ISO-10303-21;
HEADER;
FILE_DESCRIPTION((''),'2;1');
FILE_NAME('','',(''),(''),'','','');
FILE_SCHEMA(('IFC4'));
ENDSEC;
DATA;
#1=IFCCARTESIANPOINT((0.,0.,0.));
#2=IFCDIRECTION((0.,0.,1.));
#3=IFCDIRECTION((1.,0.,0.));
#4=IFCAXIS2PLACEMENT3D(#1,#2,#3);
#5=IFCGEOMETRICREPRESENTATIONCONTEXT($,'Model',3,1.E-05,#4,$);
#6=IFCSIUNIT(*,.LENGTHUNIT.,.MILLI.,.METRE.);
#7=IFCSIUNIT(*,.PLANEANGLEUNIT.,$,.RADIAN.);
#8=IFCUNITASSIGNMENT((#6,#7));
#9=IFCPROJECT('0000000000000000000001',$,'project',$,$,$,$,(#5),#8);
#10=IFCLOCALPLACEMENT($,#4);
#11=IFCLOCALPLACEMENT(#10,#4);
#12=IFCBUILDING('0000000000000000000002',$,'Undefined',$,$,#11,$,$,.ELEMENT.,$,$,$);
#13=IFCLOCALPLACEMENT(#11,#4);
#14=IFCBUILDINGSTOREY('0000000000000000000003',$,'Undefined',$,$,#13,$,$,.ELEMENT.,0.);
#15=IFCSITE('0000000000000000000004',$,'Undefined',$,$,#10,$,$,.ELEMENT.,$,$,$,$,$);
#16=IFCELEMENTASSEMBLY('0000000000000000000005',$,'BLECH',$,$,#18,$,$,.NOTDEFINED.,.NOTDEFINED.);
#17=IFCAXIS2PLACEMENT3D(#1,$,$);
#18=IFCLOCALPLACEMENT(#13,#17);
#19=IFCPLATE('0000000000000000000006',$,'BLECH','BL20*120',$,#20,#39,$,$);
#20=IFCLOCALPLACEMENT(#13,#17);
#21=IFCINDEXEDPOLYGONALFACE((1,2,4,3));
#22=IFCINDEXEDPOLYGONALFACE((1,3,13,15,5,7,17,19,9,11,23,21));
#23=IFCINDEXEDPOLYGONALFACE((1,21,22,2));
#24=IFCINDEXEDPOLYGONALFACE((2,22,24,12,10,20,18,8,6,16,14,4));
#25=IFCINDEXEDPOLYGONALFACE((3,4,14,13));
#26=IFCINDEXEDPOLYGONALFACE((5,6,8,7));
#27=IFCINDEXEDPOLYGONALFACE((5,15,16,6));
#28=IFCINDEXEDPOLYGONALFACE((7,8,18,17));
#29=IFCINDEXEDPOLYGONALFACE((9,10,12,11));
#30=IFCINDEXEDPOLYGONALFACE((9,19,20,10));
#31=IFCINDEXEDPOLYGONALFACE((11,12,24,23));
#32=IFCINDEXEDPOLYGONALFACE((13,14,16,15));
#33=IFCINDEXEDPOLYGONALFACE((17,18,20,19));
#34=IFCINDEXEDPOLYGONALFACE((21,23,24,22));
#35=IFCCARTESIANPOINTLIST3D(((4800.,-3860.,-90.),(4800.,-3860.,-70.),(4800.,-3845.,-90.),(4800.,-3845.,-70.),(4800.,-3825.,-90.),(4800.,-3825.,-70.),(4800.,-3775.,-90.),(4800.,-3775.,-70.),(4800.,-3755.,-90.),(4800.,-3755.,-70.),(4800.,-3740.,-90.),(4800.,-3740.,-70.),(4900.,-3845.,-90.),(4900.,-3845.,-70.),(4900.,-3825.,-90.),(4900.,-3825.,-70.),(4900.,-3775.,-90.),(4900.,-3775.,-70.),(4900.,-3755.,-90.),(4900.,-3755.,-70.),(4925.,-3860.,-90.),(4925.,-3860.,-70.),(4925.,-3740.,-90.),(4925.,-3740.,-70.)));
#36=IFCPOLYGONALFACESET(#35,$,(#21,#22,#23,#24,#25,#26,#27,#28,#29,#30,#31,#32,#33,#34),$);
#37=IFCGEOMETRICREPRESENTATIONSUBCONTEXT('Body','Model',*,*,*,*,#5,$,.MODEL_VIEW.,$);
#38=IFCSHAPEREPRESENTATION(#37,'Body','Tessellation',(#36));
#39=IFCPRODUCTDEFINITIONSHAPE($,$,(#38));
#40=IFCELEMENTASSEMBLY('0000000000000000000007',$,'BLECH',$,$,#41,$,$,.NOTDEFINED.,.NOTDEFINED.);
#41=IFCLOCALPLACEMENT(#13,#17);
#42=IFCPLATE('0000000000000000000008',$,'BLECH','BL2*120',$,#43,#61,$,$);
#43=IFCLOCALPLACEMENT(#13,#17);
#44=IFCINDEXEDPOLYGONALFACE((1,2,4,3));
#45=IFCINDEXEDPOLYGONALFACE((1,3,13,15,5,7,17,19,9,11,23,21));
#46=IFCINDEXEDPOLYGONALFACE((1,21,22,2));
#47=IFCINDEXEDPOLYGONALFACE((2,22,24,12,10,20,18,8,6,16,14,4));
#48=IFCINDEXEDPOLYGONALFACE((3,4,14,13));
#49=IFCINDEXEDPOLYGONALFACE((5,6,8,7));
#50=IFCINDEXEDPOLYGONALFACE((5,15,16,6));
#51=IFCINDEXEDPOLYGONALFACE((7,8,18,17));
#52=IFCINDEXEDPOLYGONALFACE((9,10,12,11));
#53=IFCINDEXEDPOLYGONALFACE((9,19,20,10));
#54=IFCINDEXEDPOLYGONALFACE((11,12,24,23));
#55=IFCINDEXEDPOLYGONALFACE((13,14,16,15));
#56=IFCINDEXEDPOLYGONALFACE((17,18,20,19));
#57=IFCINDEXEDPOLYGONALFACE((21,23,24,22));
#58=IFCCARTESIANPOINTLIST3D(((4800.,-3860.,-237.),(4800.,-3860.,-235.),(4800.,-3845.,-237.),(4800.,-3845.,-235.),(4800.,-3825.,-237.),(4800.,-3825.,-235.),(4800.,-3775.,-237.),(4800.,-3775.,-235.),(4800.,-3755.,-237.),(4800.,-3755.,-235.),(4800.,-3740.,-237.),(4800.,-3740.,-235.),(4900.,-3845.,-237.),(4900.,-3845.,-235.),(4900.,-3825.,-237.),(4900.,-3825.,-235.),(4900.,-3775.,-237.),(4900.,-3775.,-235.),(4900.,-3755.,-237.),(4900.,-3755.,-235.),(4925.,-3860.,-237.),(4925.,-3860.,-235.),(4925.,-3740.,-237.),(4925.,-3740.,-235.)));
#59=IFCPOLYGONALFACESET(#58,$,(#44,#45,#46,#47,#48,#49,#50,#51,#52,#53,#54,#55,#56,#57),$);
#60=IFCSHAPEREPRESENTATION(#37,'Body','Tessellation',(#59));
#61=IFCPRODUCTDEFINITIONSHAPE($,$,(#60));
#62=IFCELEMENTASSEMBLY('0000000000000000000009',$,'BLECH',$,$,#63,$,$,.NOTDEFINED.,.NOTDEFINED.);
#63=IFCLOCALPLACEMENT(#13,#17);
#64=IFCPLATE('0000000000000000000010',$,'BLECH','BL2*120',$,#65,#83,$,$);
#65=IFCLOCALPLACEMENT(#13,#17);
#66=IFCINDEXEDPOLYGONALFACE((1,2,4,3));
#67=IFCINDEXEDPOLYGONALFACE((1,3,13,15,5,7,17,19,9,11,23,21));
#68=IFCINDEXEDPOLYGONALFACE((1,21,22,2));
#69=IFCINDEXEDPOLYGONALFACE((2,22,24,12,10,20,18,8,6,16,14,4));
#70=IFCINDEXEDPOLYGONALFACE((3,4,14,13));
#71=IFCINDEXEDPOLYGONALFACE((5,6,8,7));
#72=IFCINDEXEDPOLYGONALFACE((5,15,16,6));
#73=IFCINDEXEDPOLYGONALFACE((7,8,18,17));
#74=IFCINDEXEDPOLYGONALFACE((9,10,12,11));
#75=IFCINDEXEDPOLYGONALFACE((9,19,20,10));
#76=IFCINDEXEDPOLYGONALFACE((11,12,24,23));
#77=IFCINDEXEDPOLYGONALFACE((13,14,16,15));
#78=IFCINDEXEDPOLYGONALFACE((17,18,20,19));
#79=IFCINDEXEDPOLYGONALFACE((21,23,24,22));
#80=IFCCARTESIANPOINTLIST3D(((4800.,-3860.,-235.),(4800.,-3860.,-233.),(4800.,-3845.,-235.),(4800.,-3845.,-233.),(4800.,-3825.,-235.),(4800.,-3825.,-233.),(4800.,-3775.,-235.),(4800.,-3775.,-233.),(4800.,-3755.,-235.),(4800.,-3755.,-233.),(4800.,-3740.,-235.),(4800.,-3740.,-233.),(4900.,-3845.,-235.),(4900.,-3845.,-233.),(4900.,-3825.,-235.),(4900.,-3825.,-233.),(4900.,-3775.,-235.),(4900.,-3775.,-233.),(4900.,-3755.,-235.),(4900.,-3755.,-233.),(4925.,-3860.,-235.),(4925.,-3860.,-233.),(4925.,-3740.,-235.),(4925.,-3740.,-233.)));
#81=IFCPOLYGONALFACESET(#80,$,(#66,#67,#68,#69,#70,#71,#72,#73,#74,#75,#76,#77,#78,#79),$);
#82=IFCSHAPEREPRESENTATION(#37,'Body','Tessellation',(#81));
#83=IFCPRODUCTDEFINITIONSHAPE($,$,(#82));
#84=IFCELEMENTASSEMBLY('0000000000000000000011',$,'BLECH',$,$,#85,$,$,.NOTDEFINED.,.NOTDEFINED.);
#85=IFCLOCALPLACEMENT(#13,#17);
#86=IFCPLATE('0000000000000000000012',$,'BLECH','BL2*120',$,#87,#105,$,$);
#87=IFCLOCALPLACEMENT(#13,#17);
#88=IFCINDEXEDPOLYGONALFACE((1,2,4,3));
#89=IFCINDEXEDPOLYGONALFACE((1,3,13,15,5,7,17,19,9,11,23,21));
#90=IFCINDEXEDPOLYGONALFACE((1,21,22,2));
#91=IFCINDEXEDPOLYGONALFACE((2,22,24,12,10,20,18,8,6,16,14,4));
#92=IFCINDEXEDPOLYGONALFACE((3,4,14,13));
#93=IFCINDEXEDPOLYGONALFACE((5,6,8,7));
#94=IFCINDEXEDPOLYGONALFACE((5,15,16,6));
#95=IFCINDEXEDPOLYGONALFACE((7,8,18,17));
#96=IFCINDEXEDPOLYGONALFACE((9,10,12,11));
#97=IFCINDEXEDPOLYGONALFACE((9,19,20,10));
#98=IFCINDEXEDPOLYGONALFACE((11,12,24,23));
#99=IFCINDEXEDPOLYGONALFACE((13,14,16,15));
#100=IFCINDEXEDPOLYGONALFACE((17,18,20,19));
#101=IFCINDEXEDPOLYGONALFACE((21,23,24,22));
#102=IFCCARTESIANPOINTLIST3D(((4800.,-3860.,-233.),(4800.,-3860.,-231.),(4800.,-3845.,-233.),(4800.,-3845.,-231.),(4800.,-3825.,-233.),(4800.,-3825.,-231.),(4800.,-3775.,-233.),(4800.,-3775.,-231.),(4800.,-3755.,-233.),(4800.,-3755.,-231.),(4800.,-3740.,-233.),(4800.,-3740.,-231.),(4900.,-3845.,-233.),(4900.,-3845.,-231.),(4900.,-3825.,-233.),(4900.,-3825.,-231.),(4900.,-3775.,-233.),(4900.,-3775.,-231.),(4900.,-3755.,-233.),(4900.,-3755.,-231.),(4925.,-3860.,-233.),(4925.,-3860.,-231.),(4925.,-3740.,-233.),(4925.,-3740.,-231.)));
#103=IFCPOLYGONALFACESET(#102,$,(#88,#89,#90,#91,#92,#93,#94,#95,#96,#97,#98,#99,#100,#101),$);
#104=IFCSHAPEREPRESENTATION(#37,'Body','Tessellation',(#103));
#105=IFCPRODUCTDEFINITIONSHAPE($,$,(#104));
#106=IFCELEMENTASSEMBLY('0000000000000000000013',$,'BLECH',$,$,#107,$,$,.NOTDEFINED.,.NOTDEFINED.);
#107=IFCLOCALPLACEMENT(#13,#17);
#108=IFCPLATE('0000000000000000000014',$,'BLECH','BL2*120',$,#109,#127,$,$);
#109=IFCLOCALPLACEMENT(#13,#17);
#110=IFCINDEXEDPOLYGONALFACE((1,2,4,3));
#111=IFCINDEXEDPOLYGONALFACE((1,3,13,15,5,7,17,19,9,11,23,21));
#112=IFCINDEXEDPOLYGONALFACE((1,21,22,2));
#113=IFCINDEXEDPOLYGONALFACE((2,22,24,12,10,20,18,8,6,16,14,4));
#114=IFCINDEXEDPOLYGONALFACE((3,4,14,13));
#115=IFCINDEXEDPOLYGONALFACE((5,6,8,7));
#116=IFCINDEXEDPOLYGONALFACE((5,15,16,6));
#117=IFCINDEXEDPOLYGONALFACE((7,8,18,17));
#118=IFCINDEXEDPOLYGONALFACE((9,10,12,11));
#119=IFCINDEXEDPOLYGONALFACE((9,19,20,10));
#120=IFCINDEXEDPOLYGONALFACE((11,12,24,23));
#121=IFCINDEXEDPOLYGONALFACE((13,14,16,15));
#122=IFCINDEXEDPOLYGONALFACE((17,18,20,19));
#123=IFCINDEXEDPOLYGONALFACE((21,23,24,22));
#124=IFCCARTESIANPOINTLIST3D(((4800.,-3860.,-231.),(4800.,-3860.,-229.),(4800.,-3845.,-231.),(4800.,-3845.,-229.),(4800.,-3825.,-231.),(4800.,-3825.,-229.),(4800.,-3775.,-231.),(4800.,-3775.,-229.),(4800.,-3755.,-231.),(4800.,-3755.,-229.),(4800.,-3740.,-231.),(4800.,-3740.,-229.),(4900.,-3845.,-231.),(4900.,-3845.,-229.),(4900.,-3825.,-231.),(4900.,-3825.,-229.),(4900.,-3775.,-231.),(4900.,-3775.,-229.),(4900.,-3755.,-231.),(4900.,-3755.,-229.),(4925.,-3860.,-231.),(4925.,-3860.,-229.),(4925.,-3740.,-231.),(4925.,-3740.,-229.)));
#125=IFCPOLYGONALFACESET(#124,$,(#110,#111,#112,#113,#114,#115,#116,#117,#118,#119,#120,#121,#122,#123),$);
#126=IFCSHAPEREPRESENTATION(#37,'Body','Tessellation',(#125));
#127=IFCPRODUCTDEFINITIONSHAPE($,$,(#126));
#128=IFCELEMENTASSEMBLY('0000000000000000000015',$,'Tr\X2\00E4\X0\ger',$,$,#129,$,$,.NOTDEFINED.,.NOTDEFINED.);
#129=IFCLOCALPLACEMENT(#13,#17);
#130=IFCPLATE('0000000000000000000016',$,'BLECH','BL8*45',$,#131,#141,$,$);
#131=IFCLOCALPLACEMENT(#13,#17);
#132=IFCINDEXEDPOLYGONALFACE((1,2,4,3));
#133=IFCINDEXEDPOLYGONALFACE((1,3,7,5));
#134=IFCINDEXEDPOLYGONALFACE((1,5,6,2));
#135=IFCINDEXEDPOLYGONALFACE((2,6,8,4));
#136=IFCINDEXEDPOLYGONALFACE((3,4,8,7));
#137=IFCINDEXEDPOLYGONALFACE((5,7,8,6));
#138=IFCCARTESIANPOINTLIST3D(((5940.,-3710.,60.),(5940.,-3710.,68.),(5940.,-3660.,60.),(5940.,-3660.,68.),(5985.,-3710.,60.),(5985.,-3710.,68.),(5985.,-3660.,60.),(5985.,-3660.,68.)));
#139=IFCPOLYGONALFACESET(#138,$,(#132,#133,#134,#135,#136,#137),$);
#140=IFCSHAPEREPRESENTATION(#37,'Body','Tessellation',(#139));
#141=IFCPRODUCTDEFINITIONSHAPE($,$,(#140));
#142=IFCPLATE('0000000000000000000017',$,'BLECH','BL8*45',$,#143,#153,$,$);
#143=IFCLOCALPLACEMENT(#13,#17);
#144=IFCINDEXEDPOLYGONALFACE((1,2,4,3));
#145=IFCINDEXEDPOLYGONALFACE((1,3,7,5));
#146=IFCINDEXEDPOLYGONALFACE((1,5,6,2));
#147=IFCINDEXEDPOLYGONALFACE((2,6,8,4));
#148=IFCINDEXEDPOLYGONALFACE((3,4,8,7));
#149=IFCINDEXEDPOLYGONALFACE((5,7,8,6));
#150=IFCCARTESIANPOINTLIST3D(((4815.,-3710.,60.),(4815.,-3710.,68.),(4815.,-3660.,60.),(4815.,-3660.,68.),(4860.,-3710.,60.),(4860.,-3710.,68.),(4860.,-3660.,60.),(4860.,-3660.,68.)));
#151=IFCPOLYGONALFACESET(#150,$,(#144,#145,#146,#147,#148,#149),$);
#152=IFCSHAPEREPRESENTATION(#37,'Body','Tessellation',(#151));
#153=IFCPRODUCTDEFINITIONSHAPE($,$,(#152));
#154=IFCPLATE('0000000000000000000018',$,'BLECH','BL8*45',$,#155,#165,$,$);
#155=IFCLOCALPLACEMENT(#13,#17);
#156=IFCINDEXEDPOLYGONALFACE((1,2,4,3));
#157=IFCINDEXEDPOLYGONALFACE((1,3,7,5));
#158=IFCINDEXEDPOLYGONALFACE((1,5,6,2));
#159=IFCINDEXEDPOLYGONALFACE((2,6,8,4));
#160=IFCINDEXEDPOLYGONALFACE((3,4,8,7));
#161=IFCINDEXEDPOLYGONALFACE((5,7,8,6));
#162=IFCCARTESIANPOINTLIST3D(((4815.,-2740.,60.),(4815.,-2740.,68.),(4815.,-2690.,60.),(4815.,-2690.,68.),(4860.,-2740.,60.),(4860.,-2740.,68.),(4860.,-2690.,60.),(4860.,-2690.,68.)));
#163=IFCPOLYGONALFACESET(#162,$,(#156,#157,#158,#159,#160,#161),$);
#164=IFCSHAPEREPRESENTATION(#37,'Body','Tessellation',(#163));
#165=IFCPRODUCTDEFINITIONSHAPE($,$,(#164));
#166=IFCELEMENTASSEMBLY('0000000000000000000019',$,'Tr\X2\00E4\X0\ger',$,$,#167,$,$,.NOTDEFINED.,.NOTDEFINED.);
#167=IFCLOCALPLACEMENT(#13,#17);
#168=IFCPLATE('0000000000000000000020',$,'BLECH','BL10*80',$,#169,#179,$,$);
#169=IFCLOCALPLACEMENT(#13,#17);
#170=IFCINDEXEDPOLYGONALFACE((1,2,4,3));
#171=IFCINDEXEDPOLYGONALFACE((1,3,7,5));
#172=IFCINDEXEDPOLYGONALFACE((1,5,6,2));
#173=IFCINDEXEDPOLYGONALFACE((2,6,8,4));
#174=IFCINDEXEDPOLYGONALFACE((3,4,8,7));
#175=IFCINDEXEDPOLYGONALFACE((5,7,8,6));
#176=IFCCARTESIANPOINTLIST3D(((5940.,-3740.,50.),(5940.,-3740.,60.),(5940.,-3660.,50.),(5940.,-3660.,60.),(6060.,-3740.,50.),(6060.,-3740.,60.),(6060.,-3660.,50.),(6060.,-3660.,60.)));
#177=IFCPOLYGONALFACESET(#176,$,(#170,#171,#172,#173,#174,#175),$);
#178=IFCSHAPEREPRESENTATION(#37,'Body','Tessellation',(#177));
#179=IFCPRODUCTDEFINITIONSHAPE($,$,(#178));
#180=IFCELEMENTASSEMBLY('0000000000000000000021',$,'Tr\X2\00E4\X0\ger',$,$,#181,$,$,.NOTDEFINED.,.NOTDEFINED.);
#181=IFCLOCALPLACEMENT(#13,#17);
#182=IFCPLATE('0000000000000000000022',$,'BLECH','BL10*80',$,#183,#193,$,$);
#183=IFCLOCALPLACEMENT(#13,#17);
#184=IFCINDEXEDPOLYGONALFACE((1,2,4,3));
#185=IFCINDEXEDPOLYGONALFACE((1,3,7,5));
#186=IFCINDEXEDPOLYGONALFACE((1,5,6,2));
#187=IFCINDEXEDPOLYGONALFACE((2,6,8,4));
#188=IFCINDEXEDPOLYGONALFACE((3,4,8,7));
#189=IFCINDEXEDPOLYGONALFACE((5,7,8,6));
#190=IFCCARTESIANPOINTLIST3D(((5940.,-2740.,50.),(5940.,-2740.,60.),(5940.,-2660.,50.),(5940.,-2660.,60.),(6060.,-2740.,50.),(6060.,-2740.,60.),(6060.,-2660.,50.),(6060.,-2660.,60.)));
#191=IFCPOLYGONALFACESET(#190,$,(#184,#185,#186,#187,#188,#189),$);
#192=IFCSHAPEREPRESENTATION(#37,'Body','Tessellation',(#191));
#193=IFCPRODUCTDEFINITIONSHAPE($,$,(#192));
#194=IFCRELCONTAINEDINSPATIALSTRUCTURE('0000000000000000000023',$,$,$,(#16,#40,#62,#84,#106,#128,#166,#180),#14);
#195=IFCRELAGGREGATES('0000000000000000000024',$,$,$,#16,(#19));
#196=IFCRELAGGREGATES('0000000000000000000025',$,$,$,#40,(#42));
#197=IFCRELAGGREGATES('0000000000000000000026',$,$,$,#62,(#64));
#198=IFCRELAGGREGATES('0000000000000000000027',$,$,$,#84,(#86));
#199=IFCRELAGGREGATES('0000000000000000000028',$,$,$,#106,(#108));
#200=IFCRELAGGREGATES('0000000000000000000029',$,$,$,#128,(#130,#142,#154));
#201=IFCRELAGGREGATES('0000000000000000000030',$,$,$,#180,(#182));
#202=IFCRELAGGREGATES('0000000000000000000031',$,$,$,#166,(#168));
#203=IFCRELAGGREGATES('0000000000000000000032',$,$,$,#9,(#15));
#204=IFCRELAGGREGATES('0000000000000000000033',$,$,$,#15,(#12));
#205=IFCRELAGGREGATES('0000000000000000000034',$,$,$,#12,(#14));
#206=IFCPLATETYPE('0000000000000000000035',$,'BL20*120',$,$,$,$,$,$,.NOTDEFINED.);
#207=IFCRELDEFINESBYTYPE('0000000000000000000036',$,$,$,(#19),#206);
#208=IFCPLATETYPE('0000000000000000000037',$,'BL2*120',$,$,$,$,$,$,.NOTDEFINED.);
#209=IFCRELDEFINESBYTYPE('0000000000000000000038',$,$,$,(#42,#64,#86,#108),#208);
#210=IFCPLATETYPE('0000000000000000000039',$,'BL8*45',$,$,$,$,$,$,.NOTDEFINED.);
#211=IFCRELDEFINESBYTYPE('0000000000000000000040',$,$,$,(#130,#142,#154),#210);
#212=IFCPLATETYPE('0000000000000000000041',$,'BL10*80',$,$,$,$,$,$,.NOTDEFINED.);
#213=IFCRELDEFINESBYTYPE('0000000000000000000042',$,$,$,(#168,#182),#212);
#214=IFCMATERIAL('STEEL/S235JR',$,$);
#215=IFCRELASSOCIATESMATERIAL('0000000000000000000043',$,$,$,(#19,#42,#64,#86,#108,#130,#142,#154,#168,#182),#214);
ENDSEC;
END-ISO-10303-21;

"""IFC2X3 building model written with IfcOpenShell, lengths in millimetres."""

from ifc_helpers import new_model, si_unit, frame, origin_with_axes, place, context, subcontext, project, spatial, polyline, outline, extrude, material, type_object, element, aggregate, save


model = new_model("IFC2X3")

# Units and contexts
model_context = context("Model", 3, precision=1e-05, world=origin_with_axes())
body_context = subcontext(model_context, "Body", "Model", "MODEL_VIEW")
ifc_project = project(units=[si_unit("LENGTHUNIT", "METRE", prefix="MILLI"), si_unit("PLANEANGLEUNIT", "RADIAN")], contexts=[model_context])

# Site, building, storey
site_placement = place(None, origin_with_axes())
site = spatial("IfcSite", under=ifc_project, at=site_placement, Name="Undefined", CompositionType="ELEMENT")
building_placement = place(site_placement, origin_with_axes())
building = spatial("IfcBuilding", under=site, at=building_placement, Name="Undefined", CompositionType="ELEMENT")
storey_placement = place(building_placement, origin_with_axes())
storey = spatial("IfcBuildingStorey", under=building, at=storey_placement, Name="Undefined", CompositionType="ELEMENT", Elevation=0.0)

# Shared definitions
ifc_material_1 = material(Name="STEEL/S235JR")

# Element assemblies, plates
assembly_1_placement = place(storey_placement, origin_with_axes())
assembly_1 = element("IfcElementAssembly", 1, at=assembly_1_placement, inside=storey, Name="BLECH", AssemblyPlace="NOTDEFINED", PredefinedType="NOTDEFINED")
plate_type_1 = type_object("IfcPlateType", Name="BL20*120", PredefinedType="NOTDEFINED")
plate_1_placement = place(assembly_1_placement, frame((4925.0, -3740.0, -80.0), z_axis=(0.0, 0.0, 1.0), x_axis=(-1.0, 0.0, 0.0)))
plate_1 = element("IfcPlate", 2, at=plate_1_placement, type_object=plate_type_1, material=ifc_material_1, Name="BLECH", Description="BL20*120", context=body_context, shape_type="SweptSolid", body=[
    extrude(outline(polyline([(0.0, 0.0), (125.0, 0.0), (125.0, 15.0), (25.0, 15.0), (25.0, 35.0), (125.0, 35.0), (125.0, 85.0), (25.0, 85.0), (25.0, 105.0), (125.0, 105.0), (125.0, 120.0), (0.0, 120.0), (0.0, 0.0)])), frame((0.0, 0.0, -10.0), z_axis=(0.0, 0.0, 1.0), x_axis=(1.0, 0.0, 0.0)), (0.0, 0.0, 1.0), 20.0),
])
aggregate(assembly_1, [plate_1])
assembly_2_placement = place(storey_placement, origin_with_axes())
assembly_2 = element("IfcElementAssembly", 3, at=assembly_2_placement, inside=storey, Name="BLECH", AssemblyPlace="NOTDEFINED", PredefinedType="NOTDEFINED")
plate_type_2 = type_object("IfcPlateType", Name="BL2*120", PredefinedType="NOTDEFINED")
plate_2_placement = place(assembly_2_placement, frame((4925.0, -3740.0, -236.0), z_axis=(0.0, 0.0, 1.0), x_axis=(-1.0, 0.0, 0.0)))
plate_2 = element("IfcPlate", 4, at=plate_2_placement, type_object=plate_type_2, material=ifc_material_1, Name="BLECH", Description="BL2*120", context=body_context, shape_type="SweptSolid", body=[
    extrude(outline(polyline([(0.0, 0.0), (125.0, 0.0), (125.0, 15.0), (25.0, 15.0), (25.0, 35.0), (125.0, 35.0), (125.0, 85.0), (25.0, 85.0), (25.0, 105.0), (125.0, 105.0), (125.0, 120.0), (0.0, 120.0), (0.0, 0.0)])), frame((0.0, 0.0, -1.0), z_axis=(0.0, 0.0, 1.0), x_axis=(1.0, 0.0, 0.0)), (0.0, 0.0, 1.0), 2.0),
])
aggregate(assembly_2, [plate_2])
assembly_3_placement = place(storey_placement, origin_with_axes())
assembly_3 = element("IfcElementAssembly", 5, at=assembly_3_placement, inside=storey, Name="BLECH", AssemblyPlace="NOTDEFINED", PredefinedType="NOTDEFINED")
plate_3_placement = place(assembly_3_placement, frame((4925.0, -3740.0, -234.0), z_axis=(0.0, 0.0, 1.0), x_axis=(-1.0, 0.0, 0.0)))
plate_3 = element("IfcPlate", 6, at=plate_3_placement, type_object=plate_type_2, material=ifc_material_1, Name="BLECH", Description="BL2*120", context=body_context, shape_type="SweptSolid", body=[
    extrude(outline(polyline([(0.0, 0.0), (125.0, 0.0), (125.0, 15.0), (25.0, 15.0), (25.0, 35.0), (125.0, 35.0), (125.0, 85.0), (25.0, 85.0), (25.0, 105.0), (125.0, 105.0), (125.0, 120.0), (0.0, 120.0), (0.0, 0.0)])), frame((0.0, 0.0, -1.0), z_axis=(0.0, 0.0, 1.0), x_axis=(1.0, 0.0, 0.0)), (0.0, 0.0, 1.0), 2.0),
])
aggregate(assembly_3, [plate_3])
assembly_4_placement = place(storey_placement, origin_with_axes())
assembly_4 = element("IfcElementAssembly", 7, at=assembly_4_placement, inside=storey, Name="BLECH", AssemblyPlace="NOTDEFINED", PredefinedType="NOTDEFINED")
plate_4_placement = place(assembly_4_placement, frame((4925.0, -3740.0, -232.0), z_axis=(0.0, 0.0, 1.0), x_axis=(-1.0, 0.0, 0.0)))
plate_4 = element("IfcPlate", 8, at=plate_4_placement, type_object=plate_type_2, material=ifc_material_1, Name="BLECH", Description="BL2*120", context=body_context, shape_type="SweptSolid", body=[
    extrude(outline(polyline([(0.0, 0.0), (125.0, 0.0), (125.0, 15.0), (25.0, 15.0), (25.0, 35.0), (125.0, 35.0), (125.0, 85.0), (25.0, 85.0), (25.0, 105.0), (125.0, 105.0), (125.0, 120.0), (0.0, 120.0), (0.0, 0.0)])), frame((0.0, 0.0, -1.0), z_axis=(0.0, 0.0, 1.0), x_axis=(1.0, 0.0, 0.0)), (0.0, 0.0, 1.0), 2.0),
])
aggregate(assembly_4, [plate_4])
assembly_5_placement = place(storey_placement, origin_with_axes())
assembly_5 = element("IfcElementAssembly", 9, at=assembly_5_placement, inside=storey, Name="BLECH", AssemblyPlace="NOTDEFINED", PredefinedType="NOTDEFINED")
plate_5_placement = place(assembly_5_placement, frame((4925.0, -3740.0, -230.0), z_axis=(0.0, 0.0, 1.0), x_axis=(-1.0, 0.0, 0.0)))
plate_5 = element("IfcPlate", 10, at=plate_5_placement, type_object=plate_type_2, material=ifc_material_1, Name="BLECH", Description="BL2*120", context=body_context, shape_type="SweptSolid", body=[
    extrude(outline(polyline([(0.0, 0.0), (125.0, 0.0), (125.0, 15.0), (25.0, 15.0), (25.0, 35.0), (125.0, 35.0), (125.0, 85.0), (25.0, 85.0), (25.0, 105.0), (125.0, 105.0), (125.0, 120.0), (0.0, 120.0), (0.0, 0.0)])), frame((0.0, 0.0, -1.0), z_axis=(0.0, 0.0, 1.0), x_axis=(1.0, 0.0, 0.0)), (0.0, 0.0, 1.0), 2.0),
])
aggregate(assembly_5, [plate_5])

# Element assembly, plates
assembly_6_placement = place(storey_placement, origin_with_axes())
assembly_6 = element("IfcElementAssembly", 11, at=assembly_6_placement, inside=storey, Name="Träger", AssemblyPlace="NOTDEFINED", PredefinedType="NOTDEFINED")
plate_type_3 = type_object("IfcPlateType", Name="BL8*45", PredefinedType="NOTDEFINED")
plate_6_placement = place(assembly_6_placement, frame((5940.0, -3660.0, 64.0), z_axis=(0.0, 0.0, -1.0), x_axis=(1.0, 0.0, 0.0)))
plate_6 = element("IfcPlate", 12, at=plate_6_placement, type_object=plate_type_3, material=ifc_material_1, Name="BLECH", Description="BL8*45", context=body_context, shape_type="SweptSolid", body=[
    extrude(outline(polyline([(0.0, 0.0), (45.0, 0.0), (45.0, 50.0), (0.0, 50.0), (0.0, 0.0)])), frame((0.0, 0.0, -4.0), z_axis=(0.0, 0.0, 1.0), x_axis=(1.0, 0.0, 0.0)), (0.0, 0.0, 1.0), 8.0),
])
plate_7_placement = place(assembly_6_placement, frame((4860.0, -3660.0, 64.0), z_axis=(0.0, 0.0, 1.0), x_axis=(-1.0, 0.0, 0.0)))
plate_7 = element("IfcPlate", 13, at=plate_7_placement, type_object=plate_type_3, material=ifc_material_1, Name="BLECH", Description="BL8*45", context=body_context, shape_type="SweptSolid", body=[
    extrude(outline(polyline([(0.0, 0.0), (45.0, 0.0), (45.0, 50.0), (0.0, 50.0), (0.0, 0.0)])), frame((0.0, 0.0, -4.0), z_axis=(0.0, 0.0, 1.0), x_axis=(1.0, 0.0, 0.0)), (0.0, 0.0, 1.0), 8.0),
])
plate_8_placement = place(assembly_6_placement, frame((4860.0, -2740.0, 64.0), z_axis=(0.0, 0.0, -1.0), x_axis=(-1.0, 0.0, 0.0)))
plate_8 = element("IfcPlate", 14, at=plate_8_placement, type_object=plate_type_3, material=ifc_material_1, Name="BLECH", Description="BL8*45", context=body_context, shape_type="SweptSolid", body=[
    extrude(outline(polyline([(0.0, 0.0), (45.0, 0.0), (45.0, 50.0), (0.0, 50.0), (0.0, 0.0)])), frame((0.0, 0.0, -4.0), z_axis=(0.0, 0.0, 1.0), x_axis=(1.0, 0.0, 0.0)), (0.0, 0.0, 1.0), 8.0),
])
aggregate(assembly_6, [plate_6, plate_7, plate_8])

# Element assemblies, plates
assembly_7_placement = place(storey_placement, origin_with_axes())
assembly_7 = element("IfcElementAssembly", 15, at=assembly_7_placement, inside=storey, Name="Träger", AssemblyPlace="NOTDEFINED", PredefinedType="NOTDEFINED")
plate_type_4 = type_object("IfcPlateType", Name="BL10*80", PredefinedType="NOTDEFINED")
plate_9_placement = place(assembly_7_placement, frame((5940.0, -3660.0, 55.0), z_axis=(0.0, 0.0, -1.0), x_axis=(1.0, 0.0, 0.0)))
plate_9 = element("IfcPlate", 16, at=plate_9_placement, type_object=plate_type_4, material=ifc_material_1, Name="BLECH", Description="BL10*80", context=body_context, shape_type="SweptSolid", body=[
    extrude(outline(polyline([(0.0, 0.0), (120.0, 0.0), (120.0, 80.0), (0.0, 80.0), (0.0, 0.0)])), frame((0.0, 0.0, -5.0), z_axis=(0.0, 0.0, 1.0), x_axis=(1.0, 0.0, 0.0)), (0.0, 0.0, 1.0), 10.0),
])
assembly_8_placement = place(storey_placement, origin_with_axes())
assembly_8 = element("IfcElementAssembly", 17, at=assembly_8_placement, inside=storey, Name="Träger", AssemblyPlace="NOTDEFINED", PredefinedType="NOTDEFINED")
plate_10_placement = place(assembly_8_placement, frame((5940.0, -2740.0, 55.0), z_axis=(0.0, 0.0, 1.0), x_axis=(1.0, 0.0, 0.0)))
plate_10 = element("IfcPlate", 18, at=plate_10_placement, type_object=plate_type_4, material=ifc_material_1, Name="BLECH", Description="BL10*80", context=body_context, shape_type="SweptSolid", body=[
    extrude(outline(polyline([(0.0, 0.0), (120.0, 0.0), (120.0, 80.0), (0.0, 80.0), (0.0, 0.0)])), frame((0.0, 0.0, -5.0), z_axis=(0.0, 0.0, 1.0), x_axis=(1.0, 0.0, 0.0)), (0.0, 0.0, 1.0), 10.0),
])
aggregate(assembly_8, [plate_10])

aggregate(assembly_7, [plate_9])

save(model, "model.ifc")
